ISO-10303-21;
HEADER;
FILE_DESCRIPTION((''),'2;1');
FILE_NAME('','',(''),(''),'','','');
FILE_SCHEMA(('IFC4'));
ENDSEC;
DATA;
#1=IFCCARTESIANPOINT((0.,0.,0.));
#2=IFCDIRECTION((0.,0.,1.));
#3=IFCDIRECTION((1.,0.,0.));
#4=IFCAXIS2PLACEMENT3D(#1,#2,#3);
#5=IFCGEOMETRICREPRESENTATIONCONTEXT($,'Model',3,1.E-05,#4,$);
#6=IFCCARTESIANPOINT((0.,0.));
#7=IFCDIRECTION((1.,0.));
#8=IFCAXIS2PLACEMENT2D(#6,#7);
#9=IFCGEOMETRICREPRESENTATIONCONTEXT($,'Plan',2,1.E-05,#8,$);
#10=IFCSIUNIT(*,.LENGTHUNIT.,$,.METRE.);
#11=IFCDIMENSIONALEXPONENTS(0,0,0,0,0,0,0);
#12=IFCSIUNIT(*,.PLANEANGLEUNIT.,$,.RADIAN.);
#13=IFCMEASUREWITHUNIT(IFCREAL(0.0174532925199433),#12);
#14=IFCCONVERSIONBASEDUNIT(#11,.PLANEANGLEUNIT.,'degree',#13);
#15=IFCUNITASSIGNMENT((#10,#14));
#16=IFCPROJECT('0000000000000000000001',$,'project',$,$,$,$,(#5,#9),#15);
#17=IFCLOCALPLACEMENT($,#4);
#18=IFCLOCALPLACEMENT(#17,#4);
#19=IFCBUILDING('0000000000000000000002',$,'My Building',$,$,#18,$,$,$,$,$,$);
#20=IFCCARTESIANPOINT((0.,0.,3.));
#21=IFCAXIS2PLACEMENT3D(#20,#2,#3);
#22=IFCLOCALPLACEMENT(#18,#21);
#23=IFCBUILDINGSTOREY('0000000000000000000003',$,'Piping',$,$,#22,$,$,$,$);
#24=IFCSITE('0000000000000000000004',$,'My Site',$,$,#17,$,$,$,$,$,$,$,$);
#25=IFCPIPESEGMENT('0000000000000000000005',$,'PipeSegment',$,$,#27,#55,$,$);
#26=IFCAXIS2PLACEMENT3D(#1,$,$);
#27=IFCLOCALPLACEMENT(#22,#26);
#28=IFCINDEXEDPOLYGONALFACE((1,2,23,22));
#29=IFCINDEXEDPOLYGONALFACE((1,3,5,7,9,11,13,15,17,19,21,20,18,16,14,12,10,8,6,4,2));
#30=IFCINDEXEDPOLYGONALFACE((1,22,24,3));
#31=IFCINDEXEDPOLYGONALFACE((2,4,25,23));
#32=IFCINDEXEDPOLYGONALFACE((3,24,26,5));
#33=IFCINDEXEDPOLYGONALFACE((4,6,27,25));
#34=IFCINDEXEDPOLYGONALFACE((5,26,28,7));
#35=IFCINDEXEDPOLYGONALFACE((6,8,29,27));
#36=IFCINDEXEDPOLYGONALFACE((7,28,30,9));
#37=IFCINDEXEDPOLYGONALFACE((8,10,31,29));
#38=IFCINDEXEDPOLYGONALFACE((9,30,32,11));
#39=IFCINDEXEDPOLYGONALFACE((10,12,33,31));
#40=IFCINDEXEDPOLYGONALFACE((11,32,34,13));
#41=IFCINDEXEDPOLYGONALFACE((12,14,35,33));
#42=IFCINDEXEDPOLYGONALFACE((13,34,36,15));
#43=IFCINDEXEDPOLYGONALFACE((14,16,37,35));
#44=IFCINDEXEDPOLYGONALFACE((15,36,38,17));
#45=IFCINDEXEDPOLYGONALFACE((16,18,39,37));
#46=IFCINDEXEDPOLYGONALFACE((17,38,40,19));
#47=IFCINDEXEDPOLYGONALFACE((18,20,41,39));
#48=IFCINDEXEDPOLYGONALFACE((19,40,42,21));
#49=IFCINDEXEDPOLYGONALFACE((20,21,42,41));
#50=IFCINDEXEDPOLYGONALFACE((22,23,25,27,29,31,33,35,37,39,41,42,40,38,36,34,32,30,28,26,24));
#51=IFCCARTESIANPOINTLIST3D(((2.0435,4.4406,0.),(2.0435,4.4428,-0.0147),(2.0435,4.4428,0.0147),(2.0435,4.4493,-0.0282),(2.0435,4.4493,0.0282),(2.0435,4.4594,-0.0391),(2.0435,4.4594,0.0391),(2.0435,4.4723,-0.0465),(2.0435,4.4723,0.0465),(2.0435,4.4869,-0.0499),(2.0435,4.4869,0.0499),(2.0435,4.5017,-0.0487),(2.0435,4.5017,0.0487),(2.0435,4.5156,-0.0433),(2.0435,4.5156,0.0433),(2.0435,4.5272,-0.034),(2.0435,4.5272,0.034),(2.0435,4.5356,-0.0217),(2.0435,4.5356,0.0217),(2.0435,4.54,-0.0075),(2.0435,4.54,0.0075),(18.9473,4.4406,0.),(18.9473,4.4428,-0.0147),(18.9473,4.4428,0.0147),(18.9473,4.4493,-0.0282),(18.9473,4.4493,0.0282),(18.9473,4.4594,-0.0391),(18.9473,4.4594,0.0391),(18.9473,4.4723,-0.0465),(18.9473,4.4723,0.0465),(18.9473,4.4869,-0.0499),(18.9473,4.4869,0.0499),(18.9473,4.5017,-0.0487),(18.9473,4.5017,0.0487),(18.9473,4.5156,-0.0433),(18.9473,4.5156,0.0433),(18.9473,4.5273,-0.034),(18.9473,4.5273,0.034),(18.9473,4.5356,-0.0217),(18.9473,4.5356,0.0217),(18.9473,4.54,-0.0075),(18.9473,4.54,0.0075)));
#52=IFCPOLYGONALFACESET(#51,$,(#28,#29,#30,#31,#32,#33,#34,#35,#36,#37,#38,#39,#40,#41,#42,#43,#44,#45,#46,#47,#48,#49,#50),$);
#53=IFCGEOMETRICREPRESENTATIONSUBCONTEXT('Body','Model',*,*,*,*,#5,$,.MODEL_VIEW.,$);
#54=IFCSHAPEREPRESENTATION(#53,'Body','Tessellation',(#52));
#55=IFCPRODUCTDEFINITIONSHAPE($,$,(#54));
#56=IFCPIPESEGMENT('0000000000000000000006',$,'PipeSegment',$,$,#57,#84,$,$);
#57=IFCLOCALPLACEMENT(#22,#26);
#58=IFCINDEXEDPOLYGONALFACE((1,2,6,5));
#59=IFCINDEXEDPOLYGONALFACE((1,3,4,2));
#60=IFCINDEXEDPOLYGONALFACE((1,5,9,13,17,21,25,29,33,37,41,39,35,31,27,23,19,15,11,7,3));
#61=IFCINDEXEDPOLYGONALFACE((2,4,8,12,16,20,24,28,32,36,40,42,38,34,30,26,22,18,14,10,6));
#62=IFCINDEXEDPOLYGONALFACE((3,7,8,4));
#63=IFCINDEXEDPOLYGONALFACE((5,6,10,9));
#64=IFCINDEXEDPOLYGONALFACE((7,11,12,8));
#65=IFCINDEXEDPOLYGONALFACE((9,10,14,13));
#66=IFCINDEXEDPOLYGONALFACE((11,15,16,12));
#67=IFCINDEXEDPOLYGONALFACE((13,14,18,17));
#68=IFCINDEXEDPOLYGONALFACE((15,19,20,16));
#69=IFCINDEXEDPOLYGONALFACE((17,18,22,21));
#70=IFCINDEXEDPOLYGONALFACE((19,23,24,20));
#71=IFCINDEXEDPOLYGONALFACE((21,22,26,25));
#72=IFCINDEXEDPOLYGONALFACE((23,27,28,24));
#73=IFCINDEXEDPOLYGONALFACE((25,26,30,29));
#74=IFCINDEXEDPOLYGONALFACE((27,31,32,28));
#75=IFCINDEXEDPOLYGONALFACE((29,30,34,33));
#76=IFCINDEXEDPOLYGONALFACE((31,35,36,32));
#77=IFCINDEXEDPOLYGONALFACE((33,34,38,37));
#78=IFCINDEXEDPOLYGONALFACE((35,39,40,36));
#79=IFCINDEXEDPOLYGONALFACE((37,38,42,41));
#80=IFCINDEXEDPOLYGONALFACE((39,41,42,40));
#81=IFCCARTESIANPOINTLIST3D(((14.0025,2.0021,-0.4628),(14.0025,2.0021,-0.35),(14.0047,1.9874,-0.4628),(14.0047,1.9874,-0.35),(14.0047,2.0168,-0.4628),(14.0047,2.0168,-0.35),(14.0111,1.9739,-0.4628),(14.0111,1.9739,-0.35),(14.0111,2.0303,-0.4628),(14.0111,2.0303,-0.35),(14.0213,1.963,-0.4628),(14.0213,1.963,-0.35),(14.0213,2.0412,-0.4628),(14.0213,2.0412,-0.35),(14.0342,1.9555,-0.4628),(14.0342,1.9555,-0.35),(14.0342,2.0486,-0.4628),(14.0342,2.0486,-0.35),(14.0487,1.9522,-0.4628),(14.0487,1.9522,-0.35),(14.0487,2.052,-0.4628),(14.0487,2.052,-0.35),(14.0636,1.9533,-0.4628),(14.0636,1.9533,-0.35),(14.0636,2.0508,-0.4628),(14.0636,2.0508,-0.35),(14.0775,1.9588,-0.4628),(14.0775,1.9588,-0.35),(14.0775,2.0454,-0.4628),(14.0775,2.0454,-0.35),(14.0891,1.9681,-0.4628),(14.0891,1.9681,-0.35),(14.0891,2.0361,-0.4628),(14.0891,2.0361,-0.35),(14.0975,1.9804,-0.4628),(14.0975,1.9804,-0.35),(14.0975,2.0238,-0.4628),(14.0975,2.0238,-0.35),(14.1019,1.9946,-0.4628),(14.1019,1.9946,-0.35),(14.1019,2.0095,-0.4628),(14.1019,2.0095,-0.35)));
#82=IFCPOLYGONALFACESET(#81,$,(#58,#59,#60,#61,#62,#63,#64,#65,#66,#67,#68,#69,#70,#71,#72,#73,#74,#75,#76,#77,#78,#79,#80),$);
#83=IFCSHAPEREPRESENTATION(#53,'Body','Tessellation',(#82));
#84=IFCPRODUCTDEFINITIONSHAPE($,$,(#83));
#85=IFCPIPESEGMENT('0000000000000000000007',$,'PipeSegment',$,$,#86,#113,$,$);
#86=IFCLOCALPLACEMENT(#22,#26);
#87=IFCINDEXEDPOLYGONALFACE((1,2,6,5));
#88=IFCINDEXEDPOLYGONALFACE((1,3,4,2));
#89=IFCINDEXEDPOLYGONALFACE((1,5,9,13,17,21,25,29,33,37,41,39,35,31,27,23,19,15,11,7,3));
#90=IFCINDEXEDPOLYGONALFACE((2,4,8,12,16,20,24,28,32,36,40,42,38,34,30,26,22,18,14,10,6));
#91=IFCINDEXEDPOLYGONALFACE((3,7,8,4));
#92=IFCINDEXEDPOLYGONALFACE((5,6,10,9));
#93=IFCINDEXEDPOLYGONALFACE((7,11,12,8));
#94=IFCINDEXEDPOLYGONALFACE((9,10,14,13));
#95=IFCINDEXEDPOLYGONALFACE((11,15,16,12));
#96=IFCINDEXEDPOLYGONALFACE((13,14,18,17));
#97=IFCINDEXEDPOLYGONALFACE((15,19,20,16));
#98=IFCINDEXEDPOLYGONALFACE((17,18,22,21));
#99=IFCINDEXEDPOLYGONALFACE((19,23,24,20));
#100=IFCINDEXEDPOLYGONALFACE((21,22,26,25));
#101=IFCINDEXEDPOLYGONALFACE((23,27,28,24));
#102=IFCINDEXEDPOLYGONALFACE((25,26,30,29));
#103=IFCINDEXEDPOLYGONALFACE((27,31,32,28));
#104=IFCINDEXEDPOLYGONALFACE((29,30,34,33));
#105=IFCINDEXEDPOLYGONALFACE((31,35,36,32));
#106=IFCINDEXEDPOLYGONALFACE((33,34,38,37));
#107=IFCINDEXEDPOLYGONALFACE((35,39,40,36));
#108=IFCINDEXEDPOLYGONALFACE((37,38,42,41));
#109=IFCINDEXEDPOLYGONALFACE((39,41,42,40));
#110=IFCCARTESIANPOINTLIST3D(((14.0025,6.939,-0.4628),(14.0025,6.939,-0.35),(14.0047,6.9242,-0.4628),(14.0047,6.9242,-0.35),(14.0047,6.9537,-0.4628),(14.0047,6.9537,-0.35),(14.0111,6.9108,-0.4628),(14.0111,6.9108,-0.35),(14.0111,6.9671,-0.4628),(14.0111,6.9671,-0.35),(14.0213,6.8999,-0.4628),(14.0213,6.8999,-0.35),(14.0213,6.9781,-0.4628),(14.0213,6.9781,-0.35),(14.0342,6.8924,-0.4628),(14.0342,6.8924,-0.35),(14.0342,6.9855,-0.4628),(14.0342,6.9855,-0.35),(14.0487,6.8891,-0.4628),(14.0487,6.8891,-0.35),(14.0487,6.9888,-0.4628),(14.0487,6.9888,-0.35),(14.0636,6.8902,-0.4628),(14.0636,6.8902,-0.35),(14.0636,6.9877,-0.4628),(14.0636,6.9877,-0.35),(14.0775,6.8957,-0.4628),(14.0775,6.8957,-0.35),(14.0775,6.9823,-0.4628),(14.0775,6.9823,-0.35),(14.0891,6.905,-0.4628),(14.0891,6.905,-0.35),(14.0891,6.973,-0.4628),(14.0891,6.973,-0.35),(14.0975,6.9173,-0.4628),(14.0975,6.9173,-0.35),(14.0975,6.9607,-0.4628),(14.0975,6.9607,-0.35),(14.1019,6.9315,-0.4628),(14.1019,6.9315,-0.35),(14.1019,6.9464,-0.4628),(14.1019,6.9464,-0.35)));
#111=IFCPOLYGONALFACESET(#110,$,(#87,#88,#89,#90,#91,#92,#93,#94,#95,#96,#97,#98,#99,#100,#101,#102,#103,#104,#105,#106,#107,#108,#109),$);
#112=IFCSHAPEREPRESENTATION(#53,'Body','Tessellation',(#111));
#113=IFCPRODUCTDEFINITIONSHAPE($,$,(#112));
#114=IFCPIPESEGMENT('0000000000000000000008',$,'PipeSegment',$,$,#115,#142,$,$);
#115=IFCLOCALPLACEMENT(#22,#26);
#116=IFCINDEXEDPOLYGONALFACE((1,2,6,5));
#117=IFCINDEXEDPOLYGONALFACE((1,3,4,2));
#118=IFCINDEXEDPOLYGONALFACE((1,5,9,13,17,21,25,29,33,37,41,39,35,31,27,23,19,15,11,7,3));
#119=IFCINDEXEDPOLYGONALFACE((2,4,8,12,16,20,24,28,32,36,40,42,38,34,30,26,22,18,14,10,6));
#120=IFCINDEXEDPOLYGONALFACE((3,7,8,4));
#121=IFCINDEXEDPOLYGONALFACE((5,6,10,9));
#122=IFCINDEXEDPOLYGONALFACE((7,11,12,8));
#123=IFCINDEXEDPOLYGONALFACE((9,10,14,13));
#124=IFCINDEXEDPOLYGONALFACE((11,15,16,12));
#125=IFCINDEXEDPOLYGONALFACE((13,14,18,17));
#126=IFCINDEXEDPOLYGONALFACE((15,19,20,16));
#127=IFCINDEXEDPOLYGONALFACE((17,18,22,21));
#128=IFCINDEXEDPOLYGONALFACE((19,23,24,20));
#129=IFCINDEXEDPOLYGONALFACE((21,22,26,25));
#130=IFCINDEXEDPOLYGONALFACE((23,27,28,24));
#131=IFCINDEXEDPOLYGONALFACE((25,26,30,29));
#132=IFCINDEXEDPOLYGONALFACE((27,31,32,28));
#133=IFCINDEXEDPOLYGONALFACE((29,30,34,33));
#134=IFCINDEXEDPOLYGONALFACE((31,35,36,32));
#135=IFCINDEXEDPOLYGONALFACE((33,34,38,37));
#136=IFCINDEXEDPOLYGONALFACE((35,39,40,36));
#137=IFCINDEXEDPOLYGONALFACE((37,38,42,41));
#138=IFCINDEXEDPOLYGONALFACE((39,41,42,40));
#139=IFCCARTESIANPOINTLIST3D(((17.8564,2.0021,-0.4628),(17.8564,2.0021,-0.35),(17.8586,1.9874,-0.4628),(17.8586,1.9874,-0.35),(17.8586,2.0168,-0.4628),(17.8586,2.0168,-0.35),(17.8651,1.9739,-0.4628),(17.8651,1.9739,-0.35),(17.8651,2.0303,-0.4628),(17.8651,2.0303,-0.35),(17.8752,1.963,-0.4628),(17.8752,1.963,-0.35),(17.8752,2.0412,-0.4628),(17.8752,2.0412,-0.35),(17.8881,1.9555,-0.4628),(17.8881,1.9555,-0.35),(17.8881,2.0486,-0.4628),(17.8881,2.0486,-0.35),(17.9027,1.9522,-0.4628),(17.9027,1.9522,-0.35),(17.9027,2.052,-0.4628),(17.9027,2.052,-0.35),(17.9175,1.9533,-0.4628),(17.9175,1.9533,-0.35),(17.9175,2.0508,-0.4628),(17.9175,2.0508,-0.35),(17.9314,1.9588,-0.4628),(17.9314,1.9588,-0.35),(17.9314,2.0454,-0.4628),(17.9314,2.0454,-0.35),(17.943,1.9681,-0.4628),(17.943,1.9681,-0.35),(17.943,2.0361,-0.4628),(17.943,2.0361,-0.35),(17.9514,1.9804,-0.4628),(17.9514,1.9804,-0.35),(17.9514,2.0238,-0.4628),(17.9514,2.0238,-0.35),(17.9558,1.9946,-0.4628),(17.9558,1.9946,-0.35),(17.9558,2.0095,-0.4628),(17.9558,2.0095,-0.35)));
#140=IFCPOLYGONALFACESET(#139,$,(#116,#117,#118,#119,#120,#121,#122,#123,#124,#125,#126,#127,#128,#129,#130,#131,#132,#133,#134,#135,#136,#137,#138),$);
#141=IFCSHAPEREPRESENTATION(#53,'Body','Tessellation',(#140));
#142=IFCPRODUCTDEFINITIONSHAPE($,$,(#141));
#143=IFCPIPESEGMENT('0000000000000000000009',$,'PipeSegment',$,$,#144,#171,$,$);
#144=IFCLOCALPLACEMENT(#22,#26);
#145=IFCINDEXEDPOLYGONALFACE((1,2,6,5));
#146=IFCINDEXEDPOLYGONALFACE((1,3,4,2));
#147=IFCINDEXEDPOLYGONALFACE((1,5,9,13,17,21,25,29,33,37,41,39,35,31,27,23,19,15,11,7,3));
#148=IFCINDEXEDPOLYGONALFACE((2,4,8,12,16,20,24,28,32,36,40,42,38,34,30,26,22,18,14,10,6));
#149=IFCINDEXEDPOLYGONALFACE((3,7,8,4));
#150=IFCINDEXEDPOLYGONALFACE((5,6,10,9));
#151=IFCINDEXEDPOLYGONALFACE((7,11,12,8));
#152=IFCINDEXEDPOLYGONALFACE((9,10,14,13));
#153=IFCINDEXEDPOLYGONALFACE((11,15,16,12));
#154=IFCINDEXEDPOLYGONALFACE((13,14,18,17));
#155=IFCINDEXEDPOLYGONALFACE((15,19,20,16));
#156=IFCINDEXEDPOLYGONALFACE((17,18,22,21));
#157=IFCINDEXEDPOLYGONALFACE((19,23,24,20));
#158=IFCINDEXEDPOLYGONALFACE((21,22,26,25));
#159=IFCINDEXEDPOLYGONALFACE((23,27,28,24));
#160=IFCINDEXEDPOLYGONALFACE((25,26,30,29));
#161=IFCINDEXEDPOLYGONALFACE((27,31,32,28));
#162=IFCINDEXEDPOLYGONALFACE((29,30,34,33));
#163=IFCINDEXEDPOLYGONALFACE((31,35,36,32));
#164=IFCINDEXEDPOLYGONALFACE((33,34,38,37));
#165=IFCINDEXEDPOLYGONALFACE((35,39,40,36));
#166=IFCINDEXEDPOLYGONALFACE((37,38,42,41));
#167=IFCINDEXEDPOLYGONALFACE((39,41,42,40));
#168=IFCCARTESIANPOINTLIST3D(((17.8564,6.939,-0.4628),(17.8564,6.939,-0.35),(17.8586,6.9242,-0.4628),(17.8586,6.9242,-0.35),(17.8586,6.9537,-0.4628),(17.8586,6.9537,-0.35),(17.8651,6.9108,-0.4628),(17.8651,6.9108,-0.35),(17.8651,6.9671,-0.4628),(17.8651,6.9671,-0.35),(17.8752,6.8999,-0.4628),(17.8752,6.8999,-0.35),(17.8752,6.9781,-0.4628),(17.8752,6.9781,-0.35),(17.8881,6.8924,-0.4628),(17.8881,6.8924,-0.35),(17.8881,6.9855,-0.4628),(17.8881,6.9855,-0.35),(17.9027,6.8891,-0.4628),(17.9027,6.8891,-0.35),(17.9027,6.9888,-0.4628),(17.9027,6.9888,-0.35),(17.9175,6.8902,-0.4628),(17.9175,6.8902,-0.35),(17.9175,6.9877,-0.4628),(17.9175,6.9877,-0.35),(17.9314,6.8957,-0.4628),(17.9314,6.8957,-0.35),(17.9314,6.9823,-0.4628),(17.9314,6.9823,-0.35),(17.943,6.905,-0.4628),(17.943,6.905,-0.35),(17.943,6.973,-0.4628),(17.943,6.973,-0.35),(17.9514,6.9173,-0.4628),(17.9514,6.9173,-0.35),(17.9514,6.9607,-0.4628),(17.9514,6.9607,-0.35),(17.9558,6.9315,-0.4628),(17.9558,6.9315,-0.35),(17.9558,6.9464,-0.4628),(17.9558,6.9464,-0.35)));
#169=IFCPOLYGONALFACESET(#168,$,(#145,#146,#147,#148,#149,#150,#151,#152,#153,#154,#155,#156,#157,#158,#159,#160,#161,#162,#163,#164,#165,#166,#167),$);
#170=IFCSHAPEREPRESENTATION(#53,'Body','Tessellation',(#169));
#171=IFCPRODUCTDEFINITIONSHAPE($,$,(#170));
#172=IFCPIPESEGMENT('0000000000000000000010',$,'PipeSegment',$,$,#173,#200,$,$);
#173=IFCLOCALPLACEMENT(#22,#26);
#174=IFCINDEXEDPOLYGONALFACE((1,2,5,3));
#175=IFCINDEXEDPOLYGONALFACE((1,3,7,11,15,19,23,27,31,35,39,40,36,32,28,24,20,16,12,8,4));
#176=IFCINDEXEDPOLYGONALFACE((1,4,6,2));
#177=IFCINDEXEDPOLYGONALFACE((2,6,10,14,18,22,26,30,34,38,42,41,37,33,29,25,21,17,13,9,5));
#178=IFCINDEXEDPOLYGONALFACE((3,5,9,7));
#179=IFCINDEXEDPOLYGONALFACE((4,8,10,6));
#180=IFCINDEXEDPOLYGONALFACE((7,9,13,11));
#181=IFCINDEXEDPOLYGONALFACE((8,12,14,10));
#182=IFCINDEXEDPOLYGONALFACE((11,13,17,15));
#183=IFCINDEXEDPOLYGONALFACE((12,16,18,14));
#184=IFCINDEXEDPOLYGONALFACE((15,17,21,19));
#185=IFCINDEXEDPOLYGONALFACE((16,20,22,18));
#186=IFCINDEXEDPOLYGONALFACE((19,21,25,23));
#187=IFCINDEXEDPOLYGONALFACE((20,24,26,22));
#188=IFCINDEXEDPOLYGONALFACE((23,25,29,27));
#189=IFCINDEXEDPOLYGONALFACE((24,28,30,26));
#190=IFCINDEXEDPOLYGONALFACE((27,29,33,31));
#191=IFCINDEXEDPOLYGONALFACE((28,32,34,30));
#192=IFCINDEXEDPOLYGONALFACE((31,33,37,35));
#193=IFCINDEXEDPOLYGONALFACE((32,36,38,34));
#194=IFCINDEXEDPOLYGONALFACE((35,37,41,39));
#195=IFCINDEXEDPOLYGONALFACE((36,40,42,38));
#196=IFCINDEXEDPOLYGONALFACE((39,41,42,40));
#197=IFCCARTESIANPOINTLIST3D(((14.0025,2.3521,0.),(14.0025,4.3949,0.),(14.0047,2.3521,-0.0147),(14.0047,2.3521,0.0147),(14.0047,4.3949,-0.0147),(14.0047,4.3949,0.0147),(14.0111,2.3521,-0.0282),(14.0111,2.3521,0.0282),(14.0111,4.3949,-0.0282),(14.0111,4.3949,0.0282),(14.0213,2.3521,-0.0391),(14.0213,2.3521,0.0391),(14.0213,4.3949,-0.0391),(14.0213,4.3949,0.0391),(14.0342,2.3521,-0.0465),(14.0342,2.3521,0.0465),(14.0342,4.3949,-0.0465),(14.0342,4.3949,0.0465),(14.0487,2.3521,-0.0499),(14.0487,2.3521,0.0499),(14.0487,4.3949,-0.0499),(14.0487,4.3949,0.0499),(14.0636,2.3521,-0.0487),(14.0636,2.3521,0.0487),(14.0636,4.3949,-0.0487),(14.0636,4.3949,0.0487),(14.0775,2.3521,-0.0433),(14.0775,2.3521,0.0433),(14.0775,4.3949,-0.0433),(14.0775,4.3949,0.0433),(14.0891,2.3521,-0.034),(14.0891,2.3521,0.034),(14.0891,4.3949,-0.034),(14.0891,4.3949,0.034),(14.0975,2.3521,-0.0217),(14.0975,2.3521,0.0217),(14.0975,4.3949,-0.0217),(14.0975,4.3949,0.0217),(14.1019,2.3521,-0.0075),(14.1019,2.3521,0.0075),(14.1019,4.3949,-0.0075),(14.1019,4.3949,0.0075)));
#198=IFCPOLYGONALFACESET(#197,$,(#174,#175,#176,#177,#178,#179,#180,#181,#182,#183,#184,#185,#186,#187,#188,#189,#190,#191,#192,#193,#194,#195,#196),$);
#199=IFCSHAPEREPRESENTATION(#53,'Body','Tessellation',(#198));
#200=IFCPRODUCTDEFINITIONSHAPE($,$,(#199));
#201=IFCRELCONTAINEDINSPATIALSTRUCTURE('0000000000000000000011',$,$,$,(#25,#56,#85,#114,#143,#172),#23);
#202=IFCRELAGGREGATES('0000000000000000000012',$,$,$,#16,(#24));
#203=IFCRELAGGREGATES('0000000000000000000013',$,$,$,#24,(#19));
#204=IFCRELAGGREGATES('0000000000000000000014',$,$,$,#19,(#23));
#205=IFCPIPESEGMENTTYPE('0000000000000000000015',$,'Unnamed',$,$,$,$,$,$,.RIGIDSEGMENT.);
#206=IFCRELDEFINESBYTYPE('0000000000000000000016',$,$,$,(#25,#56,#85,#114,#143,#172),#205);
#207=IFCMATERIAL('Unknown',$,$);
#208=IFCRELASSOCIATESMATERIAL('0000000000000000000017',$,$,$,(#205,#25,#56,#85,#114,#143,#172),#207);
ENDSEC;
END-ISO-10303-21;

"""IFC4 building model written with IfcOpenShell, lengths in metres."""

from ifc_helpers import new_model, entity, si_unit, converted_unit, frame, origin_with_axes, origin_2d_with_axis, place, context, subcontext, project, spatial, circle, extrude, material, material_profile, profile_set, profile_usage, type_object, element, save


model = new_model("IFC4")

# Units and contexts
model_context = context("Model", 3, precision=1e-05, world=origin_with_axes())
plan_context = context("Plan", 2, precision=1e-05, world=origin_2d_with_axis())
body_context = subcontext(model_context, "Body", "Model", "MODEL_VIEW")
ifc_project = project(units=[si_unit("LENGTHUNIT", "METRE"), converted_unit("PLANEANGLEUNIT", "degree", entity("IfcReal", 0.0174532925199433), si_unit("PLANEANGLEUNIT", "RADIAN"), dimensions=[0, 0, 0, 0, 0, 0, 0])], contexts=[model_context, plan_context])

# Site, building, storey
site_placement = place(None, origin_with_axes())
site = spatial("IfcSite", under=ifc_project, at=site_placement, Name="My Site")
building_placement = place(site_placement, origin_with_axes())
building = spatial("IfcBuilding", under=site, at=building_placement, Name="My Building")
storey_placement = place(building_placement, frame((0.0, 0.0, 3.0), z_axis=(0.0, 0.0, 1.0), x_axis=(1.0, 0.0, 0.0)))
storey = spatial("IfcBuildingStorey", under=building, at=storey_placement, Name="Piping")

# Pipe segments
ifc_material = material(Name="Unknown")
ifc_material_profile_1 = material_profile(ifc_material, circle(Radius=0.05))
ifc_profile_set_1 = profile_set([ifc_material_profile_1])
ifc_profile_usage_1 = profile_usage(ifc_profile_set_1, cardinal=5)
pipe_segment_type = type_object("IfcPipeSegmentType", Name="Unnamed", PredefinedType="RIGIDSEGMENT", material=ifc_profile_set_1)
pipe_segment_1_placement = place(storey_placement, frame((18.9473, 4.4906, 0.0), z_axis=(-1.0, 0.0, 0.0), x_axis=(0.0, -1.0, 0.0)))
element("IfcPipeSegment", 1, at=pipe_segment_1_placement, inside=storey, type_object=pipe_segment_type, material=ifc_profile_usage_1, Name="PipeSegment", context=body_context, shape_type="SweptSolid", body=[
    extrude(circle(Radius=0.05), origin_with_axes(), (0.0, 0.0, 1.0), 16.9038),
])
ifc_profile_usage_2 = profile_usage(ifc_profile_set_1, cardinal=5)
pipe_segment_2_placement = place(storey_placement, frame((14.0525, 2.0021, -0.35), z_axis=(0.0, 0.0, -1.0), x_axis=(-1.0, 0.0, 0.0)))
element("IfcPipeSegment", 2, at=pipe_segment_2_placement, inside=storey, type_object=pipe_segment_type, material=ifc_profile_usage_2, Name="PipeSegment", context=body_context, shape_type="SweptSolid", body=[
    extrude(circle(Radius=0.05), origin_with_axes(), (0.0, 0.0, 1.0), 0.1128),
])
ifc_profile_usage_3 = profile_usage(ifc_profile_set_1, cardinal=5)
pipe_segment_3_placement = place(storey_placement, frame((14.0525, 6.939, -0.35), z_axis=(0.0, 0.0, -1.0), x_axis=(-1.0, 0.0, 0.0)))
element("IfcPipeSegment", 3, at=pipe_segment_3_placement, inside=storey, type_object=pipe_segment_type, material=ifc_profile_usage_3, Name="PipeSegment", context=body_context, shape_type="SweptSolid", body=[
    extrude(circle(Radius=0.05), origin_with_axes(), (0.0, 0.0, 1.0), 0.1128),
])
ifc_profile_usage_4 = profile_usage(ifc_profile_set_1, cardinal=5)
pipe_segment_4_placement = place(storey_placement, frame((17.9064, 2.0021, -0.35), z_axis=(0.0, 0.0, -1.0), x_axis=(-1.0, 0.0, 0.0)))
element("IfcPipeSegment", 4, at=pipe_segment_4_placement, inside=storey, type_object=pipe_segment_type, material=ifc_profile_usage_4, Name="PipeSegment", context=body_context, shape_type="SweptSolid", body=[
    extrude(circle(Radius=0.05), origin_with_axes(), (0.0, 0.0, 1.0), 0.1128),
])
ifc_profile_usage_5 = profile_usage(ifc_profile_set_1, cardinal=5)
pipe_segment_5_placement = place(storey_placement, frame((17.9064, 6.939, -0.35), z_axis=(0.0, 0.0, -1.0), x_axis=(-1.0, 0.0, 0.0)))
element("IfcPipeSegment", 5, at=pipe_segment_5_placement, inside=storey, type_object=pipe_segment_type, material=ifc_profile_usage_5, Name="PipeSegment", context=body_context, shape_type="SweptSolid", body=[
    extrude(circle(Radius=0.05), origin_with_axes(), (0.0, 0.0, 1.0), 0.1128),
])
ifc_profile_usage_6 = profile_usage(ifc_profile_set_1, cardinal=5)
pipe_segment_6_placement = place(storey_placement, frame((14.0525, 2.3521, 0.0), z_axis=(0.0, 1.0, 0.0), x_axis=(-1.0, 0.0, 0.0)))
element("IfcPipeSegment", 6, at=pipe_segment_6_placement, inside=storey, type_object=pipe_segment_type, material=ifc_profile_usage_6, Name="PipeSegment", context=body_context, shape_type="SweptSolid", body=[
    extrude(circle(Radius=0.05), origin_with_axes(), (0.0, 0.0, 1.0), 2.0428),
])

save(model, "model.ifc")
